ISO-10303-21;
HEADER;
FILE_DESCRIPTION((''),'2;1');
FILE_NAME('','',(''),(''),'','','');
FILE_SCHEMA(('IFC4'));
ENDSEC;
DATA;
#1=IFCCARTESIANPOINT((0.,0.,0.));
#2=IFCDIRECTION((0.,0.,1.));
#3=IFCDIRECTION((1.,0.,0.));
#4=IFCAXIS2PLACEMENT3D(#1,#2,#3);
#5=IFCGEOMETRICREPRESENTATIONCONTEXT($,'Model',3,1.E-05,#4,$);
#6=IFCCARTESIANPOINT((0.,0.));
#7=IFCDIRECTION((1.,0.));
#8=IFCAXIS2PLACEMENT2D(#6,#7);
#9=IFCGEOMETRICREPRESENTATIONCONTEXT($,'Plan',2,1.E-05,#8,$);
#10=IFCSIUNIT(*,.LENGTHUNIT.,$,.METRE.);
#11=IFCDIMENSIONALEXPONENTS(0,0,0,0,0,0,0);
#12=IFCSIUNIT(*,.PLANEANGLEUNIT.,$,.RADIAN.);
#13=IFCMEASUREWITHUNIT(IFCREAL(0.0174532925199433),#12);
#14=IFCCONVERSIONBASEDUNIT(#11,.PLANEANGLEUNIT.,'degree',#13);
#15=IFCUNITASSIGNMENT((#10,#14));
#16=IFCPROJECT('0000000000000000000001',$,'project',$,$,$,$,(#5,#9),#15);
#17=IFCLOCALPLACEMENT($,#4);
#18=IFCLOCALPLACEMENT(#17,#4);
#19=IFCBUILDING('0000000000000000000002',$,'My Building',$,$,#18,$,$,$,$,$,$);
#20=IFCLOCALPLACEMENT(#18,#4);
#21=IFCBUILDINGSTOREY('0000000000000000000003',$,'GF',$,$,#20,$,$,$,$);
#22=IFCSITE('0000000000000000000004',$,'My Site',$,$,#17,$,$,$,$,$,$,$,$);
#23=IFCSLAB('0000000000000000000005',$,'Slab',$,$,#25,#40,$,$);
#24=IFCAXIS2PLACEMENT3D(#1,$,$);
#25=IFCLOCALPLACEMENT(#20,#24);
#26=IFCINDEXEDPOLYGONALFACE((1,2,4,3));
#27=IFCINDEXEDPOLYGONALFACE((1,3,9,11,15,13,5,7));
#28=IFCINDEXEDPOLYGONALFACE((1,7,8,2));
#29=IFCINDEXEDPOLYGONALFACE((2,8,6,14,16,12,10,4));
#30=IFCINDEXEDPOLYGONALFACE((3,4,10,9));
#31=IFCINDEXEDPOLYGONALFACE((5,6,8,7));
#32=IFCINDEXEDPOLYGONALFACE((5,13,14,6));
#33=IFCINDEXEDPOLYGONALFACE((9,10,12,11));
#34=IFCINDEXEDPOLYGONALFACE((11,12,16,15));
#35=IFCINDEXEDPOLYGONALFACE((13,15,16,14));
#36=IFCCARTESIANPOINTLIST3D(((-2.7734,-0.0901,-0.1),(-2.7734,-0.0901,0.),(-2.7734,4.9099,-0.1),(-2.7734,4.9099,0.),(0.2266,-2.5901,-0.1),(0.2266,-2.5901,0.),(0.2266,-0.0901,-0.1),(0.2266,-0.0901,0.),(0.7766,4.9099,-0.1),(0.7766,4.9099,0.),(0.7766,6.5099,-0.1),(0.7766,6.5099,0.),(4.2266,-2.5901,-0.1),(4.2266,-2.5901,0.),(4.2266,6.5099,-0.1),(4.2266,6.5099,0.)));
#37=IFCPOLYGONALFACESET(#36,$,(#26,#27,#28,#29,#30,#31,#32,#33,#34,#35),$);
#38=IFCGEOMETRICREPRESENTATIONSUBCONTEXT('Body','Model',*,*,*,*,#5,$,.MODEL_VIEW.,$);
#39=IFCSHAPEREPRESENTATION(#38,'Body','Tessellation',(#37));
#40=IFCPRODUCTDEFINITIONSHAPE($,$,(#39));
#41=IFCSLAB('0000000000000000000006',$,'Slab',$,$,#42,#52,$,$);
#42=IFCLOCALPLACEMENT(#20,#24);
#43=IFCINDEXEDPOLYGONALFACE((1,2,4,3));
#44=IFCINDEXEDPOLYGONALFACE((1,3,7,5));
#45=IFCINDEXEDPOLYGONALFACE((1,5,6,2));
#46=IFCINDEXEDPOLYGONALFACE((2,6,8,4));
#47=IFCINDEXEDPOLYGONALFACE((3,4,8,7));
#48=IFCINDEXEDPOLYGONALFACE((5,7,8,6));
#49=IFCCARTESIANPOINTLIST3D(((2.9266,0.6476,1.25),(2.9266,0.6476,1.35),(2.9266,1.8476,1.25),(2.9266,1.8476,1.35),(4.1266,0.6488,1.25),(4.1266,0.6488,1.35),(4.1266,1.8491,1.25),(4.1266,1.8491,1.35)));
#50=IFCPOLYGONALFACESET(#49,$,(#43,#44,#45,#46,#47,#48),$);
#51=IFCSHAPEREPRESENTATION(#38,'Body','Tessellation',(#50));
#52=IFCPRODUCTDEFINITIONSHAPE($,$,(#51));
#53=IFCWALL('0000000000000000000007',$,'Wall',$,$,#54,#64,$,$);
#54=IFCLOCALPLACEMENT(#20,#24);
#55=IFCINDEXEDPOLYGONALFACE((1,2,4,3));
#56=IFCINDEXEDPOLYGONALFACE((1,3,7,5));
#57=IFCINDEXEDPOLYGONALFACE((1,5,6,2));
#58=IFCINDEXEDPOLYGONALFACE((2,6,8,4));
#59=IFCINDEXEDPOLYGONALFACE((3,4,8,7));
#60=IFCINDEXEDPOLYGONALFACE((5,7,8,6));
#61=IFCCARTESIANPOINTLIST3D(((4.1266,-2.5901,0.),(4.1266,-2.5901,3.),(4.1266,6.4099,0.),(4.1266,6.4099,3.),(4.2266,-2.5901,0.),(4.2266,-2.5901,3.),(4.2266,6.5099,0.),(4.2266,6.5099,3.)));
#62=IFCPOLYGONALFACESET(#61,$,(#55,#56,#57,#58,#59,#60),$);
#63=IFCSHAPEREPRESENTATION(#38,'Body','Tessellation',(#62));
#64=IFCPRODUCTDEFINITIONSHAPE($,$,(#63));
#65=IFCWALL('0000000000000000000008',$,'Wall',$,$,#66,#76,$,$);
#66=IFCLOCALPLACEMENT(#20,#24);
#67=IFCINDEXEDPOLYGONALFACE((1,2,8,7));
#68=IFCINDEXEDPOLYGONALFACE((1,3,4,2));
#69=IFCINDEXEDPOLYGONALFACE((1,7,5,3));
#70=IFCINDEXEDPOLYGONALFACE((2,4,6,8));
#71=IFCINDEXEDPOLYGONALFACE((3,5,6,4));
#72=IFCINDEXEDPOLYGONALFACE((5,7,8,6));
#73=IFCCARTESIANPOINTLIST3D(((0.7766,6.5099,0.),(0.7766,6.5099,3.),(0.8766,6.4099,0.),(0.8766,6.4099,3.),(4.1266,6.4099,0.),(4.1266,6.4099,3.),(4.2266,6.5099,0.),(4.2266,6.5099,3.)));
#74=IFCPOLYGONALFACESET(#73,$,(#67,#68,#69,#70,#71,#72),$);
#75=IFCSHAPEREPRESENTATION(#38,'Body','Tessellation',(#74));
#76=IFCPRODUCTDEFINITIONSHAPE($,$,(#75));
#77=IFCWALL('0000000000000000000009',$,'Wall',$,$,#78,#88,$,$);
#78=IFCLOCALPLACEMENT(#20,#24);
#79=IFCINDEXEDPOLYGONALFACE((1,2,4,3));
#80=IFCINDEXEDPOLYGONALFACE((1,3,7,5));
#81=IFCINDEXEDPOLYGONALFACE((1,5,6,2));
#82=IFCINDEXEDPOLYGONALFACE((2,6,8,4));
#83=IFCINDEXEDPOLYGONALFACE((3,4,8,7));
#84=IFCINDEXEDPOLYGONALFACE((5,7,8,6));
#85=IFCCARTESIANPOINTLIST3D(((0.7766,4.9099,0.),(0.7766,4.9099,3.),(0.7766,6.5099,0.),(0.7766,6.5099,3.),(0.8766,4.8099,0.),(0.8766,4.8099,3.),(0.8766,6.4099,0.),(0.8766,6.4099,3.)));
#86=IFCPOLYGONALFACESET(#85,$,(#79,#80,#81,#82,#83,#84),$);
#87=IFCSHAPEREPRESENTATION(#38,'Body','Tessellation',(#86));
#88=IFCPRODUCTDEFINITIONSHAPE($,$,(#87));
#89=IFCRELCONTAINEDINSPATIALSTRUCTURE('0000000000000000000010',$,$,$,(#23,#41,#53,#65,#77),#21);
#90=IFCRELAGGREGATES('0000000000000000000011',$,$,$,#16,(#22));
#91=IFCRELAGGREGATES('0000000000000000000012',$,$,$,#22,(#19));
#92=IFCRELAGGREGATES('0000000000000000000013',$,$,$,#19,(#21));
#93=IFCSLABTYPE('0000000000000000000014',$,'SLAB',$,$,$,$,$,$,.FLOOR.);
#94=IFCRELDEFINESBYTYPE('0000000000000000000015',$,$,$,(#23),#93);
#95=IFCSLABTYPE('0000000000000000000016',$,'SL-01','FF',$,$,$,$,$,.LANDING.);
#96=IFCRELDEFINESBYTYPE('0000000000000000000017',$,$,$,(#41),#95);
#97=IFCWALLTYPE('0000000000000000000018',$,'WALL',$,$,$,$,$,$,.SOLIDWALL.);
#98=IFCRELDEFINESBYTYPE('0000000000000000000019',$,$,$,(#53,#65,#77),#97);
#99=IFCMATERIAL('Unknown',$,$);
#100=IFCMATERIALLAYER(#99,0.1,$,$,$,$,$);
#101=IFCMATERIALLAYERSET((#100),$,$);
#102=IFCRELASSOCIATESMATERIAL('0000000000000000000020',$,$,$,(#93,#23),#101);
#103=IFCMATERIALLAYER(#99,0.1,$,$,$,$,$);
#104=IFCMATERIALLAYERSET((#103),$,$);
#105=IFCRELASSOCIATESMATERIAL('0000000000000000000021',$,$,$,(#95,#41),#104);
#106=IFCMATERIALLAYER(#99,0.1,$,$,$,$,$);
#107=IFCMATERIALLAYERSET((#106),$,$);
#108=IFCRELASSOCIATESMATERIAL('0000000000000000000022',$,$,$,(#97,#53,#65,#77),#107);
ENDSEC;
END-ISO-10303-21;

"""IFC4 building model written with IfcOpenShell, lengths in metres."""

from ifc_helpers import new_model, entity, si_unit, converted_unit, frame, origin_with_axes, origin_2d_with_axis, place, context, subcontext, project, spatial, line, indexed_curve, outline, extrude, material, layer, layer_set, layer_usage, type_object, element, save


model = new_model("IFC4")

# Units and contexts
model_context = context("Model", 3, precision=1e-05, world=origin_with_axes())
plan_context = context("Plan", 2, precision=1e-05, world=origin_2d_with_axis())
body_context_1 = subcontext(model_context, "Body", "Model", "MODEL_VIEW")
ifc_project = project(units=[si_unit("LENGTHUNIT", "METRE"), converted_unit("PLANEANGLEUNIT", "degree", entity("IfcReal", 0.0174532925199433), si_unit("PLANEANGLEUNIT", "RADIAN"), dimensions=[0, 0, 0, 0, 0, 0, 0])], contexts=[model_context, plan_context])

# Site, building, storey
site_placement = place(None, origin_with_axes())
site = spatial("IfcSite", under=ifc_project, at=site_placement, Name="My Site")
building_placement = place(site_placement, origin_with_axes())
building = spatial("IfcBuilding", under=site, at=building_placement, Name="My Building")
storey_placement = place(building_placement, origin_with_axes())
storey = spatial("IfcBuildingStorey", under=building, at=storey_placement, Name="GF")

# Slabs
ifc_material_1 = material(Name="Unknown")
ifc_layer_1 = layer(ifc_material_1, 0.1)
ifc_layer_set_1 = layer_set([ifc_layer_1])
ifc_layer_usage_1 = layer_usage(ifc_layer_set_1, "AXIS3", "POSITIVE", -0.1)
slab_type_1 = type_object("IfcSlabType", Name="SLAB", PredefinedType="FLOOR", material=ifc_layer_set_1)
slab_1_placement = place(storey_placement, frame((4.2266, -2.5901, 0.0), z_axis=(0.0, 0.0, 1.0), x_axis=(1.0, 0.0, 0.0)))
element("IfcSlab", 1, at=slab_1_placement, inside=storey, type_object=slab_type_1, material=ifc_layer_usage_1, Name="Slab", context=body_context_1, shape_type="SweptSolid", body=[
    extrude(outline(indexed_curve([(0.0, 0.0), (0.0, 9.1), (-3.45, 9.1), (-3.45, 7.5), (-7.0, 7.5), (-7.0, 2.5), (-4.0, 2.5), (-4.0, 0.0), (0.0, 0.0)])), frame((0.0, 0.0, -0.1), z_axis=(0.0, 0.0, 1.0), x_axis=(1.0, 0.0, 0.0)), (0.0, 0.0, 1.0), 0.1),
])
ifc_layer_2 = layer(ifc_material_1, 0.1)
ifc_layer_set_2 = layer_set([ifc_layer_2])
ifc_layer_usage_2 = layer_usage(ifc_layer_set_2, "AXIS3", "POSITIVE", -0.1)
slab_type_2 = type_object("IfcSlabType", Name="SL-01", Description="FF", PredefinedType="LANDING", material=ifc_layer_set_2)
slab_2_placement = place(storey_placement, frame((2.9266, 1.8476, 1.35), z_axis=(0.0, 0.0, 1.0), x_axis=(1.0, 0.0, 0.0)))
element("IfcSlab", 2, at=slab_2_placement, inside=storey, type_object=slab_type_2, material=ifc_layer_usage_2, Name="Slab", context=body_context_1, shape_type="SweptSolid", body=[
    extrude(outline(indexed_curve([(0.0, 0.0), (0.0, -1.2), (1.2, -1.1988), (1.2, 0.0014), (0.0, 0.0)])), frame((0.0, 0.0, -0.1), z_axis=(0.0, 0.0, 1.0), x_axis=(1.0, 0.0, 0.0)), (0.0, 0.0, 1.0), 0.1),
])

# Shared definitions
ifc_layer_3 = layer(ifc_material_1, 0.1)
ifc_layer_set_3 = layer_set([ifc_layer_3])
wall_type = type_object("IfcWallType", Name="WALL", PredefinedType="SOLIDWALL", material=ifc_layer_set_3)

# Walls
ifc_layer_usage_3 = layer_usage(ifc_layer_set_3, "AXIS2", "POSITIVE", 0.0)
wall_1_placement = place(storey_placement, frame((4.2266, -2.5901, 0.0), z_axis=(0.0, 0.0, 1.0), x_axis=(0.0, 1.0, 0.0)))
element("IfcWall", 3, at=wall_1_placement, inside=storey, type_object=wall_type, material=ifc_layer_usage_3, Name="Wall", context=body_context_1, shape_type="SweptSolid", body=[
    extrude(outline(indexed_curve([(0.0, 0.0), (0.0, 0.1), (9.0, 0.1), (9.1, 0.0)], segments=[line(1, 2, 3, 4, 1)])), origin_with_axes(), (0.0, 0.0, 1.0), 3.0),
])
ifc_layer_usage_4 = layer_usage(ifc_layer_set_3, "AXIS2", "POSITIVE", 0.0)
wall_2_placement = place(storey_placement, frame((4.2266, 6.5099, 0.0), z_axis=(0.0, 0.0, 1.0), x_axis=(-1.0, 0.0, 0.0)))
element("IfcWall", 4, at=wall_2_placement, inside=storey, type_object=wall_type, material=ifc_layer_usage_4, Name="Wall", context=body_context_1, shape_type="SweptSolid", body=[
    extrude(outline(indexed_curve([(0.0, 0.0), (0.1, 0.1), (3.35, 0.1), (3.45, 0.0)], segments=[line(1, 2, 3, 4, 1)])), origin_with_axes(), (0.0, 0.0, 1.0), 3.0),
])
ifc_layer_usage_5 = layer_usage(ifc_layer_set_3, "AXIS2", "POSITIVE", 0.0)
wall_3_placement = place(storey_placement, frame((0.7766, 6.5099, 0.0), z_axis=(0.0, 0.0, 1.0), x_axis=(0.0, -1.0, 0.0)))
element("IfcWall", 5, at=wall_3_placement, inside=storey, type_object=wall_type, material=ifc_layer_usage_5, Name="Wall", context=body_context_1, shape_type="SweptSolid", body=[
    extrude(outline(indexed_curve([(0.0, 0.0), (0.1, 0.1), (1.7, 0.1), (1.6, 0.0)], segments=[line(1, 2, 3, 4, 1)])), origin_with_axes(), (0.0, 0.0, 1.0), 3.0),
])

save(model, "model.ifc")
